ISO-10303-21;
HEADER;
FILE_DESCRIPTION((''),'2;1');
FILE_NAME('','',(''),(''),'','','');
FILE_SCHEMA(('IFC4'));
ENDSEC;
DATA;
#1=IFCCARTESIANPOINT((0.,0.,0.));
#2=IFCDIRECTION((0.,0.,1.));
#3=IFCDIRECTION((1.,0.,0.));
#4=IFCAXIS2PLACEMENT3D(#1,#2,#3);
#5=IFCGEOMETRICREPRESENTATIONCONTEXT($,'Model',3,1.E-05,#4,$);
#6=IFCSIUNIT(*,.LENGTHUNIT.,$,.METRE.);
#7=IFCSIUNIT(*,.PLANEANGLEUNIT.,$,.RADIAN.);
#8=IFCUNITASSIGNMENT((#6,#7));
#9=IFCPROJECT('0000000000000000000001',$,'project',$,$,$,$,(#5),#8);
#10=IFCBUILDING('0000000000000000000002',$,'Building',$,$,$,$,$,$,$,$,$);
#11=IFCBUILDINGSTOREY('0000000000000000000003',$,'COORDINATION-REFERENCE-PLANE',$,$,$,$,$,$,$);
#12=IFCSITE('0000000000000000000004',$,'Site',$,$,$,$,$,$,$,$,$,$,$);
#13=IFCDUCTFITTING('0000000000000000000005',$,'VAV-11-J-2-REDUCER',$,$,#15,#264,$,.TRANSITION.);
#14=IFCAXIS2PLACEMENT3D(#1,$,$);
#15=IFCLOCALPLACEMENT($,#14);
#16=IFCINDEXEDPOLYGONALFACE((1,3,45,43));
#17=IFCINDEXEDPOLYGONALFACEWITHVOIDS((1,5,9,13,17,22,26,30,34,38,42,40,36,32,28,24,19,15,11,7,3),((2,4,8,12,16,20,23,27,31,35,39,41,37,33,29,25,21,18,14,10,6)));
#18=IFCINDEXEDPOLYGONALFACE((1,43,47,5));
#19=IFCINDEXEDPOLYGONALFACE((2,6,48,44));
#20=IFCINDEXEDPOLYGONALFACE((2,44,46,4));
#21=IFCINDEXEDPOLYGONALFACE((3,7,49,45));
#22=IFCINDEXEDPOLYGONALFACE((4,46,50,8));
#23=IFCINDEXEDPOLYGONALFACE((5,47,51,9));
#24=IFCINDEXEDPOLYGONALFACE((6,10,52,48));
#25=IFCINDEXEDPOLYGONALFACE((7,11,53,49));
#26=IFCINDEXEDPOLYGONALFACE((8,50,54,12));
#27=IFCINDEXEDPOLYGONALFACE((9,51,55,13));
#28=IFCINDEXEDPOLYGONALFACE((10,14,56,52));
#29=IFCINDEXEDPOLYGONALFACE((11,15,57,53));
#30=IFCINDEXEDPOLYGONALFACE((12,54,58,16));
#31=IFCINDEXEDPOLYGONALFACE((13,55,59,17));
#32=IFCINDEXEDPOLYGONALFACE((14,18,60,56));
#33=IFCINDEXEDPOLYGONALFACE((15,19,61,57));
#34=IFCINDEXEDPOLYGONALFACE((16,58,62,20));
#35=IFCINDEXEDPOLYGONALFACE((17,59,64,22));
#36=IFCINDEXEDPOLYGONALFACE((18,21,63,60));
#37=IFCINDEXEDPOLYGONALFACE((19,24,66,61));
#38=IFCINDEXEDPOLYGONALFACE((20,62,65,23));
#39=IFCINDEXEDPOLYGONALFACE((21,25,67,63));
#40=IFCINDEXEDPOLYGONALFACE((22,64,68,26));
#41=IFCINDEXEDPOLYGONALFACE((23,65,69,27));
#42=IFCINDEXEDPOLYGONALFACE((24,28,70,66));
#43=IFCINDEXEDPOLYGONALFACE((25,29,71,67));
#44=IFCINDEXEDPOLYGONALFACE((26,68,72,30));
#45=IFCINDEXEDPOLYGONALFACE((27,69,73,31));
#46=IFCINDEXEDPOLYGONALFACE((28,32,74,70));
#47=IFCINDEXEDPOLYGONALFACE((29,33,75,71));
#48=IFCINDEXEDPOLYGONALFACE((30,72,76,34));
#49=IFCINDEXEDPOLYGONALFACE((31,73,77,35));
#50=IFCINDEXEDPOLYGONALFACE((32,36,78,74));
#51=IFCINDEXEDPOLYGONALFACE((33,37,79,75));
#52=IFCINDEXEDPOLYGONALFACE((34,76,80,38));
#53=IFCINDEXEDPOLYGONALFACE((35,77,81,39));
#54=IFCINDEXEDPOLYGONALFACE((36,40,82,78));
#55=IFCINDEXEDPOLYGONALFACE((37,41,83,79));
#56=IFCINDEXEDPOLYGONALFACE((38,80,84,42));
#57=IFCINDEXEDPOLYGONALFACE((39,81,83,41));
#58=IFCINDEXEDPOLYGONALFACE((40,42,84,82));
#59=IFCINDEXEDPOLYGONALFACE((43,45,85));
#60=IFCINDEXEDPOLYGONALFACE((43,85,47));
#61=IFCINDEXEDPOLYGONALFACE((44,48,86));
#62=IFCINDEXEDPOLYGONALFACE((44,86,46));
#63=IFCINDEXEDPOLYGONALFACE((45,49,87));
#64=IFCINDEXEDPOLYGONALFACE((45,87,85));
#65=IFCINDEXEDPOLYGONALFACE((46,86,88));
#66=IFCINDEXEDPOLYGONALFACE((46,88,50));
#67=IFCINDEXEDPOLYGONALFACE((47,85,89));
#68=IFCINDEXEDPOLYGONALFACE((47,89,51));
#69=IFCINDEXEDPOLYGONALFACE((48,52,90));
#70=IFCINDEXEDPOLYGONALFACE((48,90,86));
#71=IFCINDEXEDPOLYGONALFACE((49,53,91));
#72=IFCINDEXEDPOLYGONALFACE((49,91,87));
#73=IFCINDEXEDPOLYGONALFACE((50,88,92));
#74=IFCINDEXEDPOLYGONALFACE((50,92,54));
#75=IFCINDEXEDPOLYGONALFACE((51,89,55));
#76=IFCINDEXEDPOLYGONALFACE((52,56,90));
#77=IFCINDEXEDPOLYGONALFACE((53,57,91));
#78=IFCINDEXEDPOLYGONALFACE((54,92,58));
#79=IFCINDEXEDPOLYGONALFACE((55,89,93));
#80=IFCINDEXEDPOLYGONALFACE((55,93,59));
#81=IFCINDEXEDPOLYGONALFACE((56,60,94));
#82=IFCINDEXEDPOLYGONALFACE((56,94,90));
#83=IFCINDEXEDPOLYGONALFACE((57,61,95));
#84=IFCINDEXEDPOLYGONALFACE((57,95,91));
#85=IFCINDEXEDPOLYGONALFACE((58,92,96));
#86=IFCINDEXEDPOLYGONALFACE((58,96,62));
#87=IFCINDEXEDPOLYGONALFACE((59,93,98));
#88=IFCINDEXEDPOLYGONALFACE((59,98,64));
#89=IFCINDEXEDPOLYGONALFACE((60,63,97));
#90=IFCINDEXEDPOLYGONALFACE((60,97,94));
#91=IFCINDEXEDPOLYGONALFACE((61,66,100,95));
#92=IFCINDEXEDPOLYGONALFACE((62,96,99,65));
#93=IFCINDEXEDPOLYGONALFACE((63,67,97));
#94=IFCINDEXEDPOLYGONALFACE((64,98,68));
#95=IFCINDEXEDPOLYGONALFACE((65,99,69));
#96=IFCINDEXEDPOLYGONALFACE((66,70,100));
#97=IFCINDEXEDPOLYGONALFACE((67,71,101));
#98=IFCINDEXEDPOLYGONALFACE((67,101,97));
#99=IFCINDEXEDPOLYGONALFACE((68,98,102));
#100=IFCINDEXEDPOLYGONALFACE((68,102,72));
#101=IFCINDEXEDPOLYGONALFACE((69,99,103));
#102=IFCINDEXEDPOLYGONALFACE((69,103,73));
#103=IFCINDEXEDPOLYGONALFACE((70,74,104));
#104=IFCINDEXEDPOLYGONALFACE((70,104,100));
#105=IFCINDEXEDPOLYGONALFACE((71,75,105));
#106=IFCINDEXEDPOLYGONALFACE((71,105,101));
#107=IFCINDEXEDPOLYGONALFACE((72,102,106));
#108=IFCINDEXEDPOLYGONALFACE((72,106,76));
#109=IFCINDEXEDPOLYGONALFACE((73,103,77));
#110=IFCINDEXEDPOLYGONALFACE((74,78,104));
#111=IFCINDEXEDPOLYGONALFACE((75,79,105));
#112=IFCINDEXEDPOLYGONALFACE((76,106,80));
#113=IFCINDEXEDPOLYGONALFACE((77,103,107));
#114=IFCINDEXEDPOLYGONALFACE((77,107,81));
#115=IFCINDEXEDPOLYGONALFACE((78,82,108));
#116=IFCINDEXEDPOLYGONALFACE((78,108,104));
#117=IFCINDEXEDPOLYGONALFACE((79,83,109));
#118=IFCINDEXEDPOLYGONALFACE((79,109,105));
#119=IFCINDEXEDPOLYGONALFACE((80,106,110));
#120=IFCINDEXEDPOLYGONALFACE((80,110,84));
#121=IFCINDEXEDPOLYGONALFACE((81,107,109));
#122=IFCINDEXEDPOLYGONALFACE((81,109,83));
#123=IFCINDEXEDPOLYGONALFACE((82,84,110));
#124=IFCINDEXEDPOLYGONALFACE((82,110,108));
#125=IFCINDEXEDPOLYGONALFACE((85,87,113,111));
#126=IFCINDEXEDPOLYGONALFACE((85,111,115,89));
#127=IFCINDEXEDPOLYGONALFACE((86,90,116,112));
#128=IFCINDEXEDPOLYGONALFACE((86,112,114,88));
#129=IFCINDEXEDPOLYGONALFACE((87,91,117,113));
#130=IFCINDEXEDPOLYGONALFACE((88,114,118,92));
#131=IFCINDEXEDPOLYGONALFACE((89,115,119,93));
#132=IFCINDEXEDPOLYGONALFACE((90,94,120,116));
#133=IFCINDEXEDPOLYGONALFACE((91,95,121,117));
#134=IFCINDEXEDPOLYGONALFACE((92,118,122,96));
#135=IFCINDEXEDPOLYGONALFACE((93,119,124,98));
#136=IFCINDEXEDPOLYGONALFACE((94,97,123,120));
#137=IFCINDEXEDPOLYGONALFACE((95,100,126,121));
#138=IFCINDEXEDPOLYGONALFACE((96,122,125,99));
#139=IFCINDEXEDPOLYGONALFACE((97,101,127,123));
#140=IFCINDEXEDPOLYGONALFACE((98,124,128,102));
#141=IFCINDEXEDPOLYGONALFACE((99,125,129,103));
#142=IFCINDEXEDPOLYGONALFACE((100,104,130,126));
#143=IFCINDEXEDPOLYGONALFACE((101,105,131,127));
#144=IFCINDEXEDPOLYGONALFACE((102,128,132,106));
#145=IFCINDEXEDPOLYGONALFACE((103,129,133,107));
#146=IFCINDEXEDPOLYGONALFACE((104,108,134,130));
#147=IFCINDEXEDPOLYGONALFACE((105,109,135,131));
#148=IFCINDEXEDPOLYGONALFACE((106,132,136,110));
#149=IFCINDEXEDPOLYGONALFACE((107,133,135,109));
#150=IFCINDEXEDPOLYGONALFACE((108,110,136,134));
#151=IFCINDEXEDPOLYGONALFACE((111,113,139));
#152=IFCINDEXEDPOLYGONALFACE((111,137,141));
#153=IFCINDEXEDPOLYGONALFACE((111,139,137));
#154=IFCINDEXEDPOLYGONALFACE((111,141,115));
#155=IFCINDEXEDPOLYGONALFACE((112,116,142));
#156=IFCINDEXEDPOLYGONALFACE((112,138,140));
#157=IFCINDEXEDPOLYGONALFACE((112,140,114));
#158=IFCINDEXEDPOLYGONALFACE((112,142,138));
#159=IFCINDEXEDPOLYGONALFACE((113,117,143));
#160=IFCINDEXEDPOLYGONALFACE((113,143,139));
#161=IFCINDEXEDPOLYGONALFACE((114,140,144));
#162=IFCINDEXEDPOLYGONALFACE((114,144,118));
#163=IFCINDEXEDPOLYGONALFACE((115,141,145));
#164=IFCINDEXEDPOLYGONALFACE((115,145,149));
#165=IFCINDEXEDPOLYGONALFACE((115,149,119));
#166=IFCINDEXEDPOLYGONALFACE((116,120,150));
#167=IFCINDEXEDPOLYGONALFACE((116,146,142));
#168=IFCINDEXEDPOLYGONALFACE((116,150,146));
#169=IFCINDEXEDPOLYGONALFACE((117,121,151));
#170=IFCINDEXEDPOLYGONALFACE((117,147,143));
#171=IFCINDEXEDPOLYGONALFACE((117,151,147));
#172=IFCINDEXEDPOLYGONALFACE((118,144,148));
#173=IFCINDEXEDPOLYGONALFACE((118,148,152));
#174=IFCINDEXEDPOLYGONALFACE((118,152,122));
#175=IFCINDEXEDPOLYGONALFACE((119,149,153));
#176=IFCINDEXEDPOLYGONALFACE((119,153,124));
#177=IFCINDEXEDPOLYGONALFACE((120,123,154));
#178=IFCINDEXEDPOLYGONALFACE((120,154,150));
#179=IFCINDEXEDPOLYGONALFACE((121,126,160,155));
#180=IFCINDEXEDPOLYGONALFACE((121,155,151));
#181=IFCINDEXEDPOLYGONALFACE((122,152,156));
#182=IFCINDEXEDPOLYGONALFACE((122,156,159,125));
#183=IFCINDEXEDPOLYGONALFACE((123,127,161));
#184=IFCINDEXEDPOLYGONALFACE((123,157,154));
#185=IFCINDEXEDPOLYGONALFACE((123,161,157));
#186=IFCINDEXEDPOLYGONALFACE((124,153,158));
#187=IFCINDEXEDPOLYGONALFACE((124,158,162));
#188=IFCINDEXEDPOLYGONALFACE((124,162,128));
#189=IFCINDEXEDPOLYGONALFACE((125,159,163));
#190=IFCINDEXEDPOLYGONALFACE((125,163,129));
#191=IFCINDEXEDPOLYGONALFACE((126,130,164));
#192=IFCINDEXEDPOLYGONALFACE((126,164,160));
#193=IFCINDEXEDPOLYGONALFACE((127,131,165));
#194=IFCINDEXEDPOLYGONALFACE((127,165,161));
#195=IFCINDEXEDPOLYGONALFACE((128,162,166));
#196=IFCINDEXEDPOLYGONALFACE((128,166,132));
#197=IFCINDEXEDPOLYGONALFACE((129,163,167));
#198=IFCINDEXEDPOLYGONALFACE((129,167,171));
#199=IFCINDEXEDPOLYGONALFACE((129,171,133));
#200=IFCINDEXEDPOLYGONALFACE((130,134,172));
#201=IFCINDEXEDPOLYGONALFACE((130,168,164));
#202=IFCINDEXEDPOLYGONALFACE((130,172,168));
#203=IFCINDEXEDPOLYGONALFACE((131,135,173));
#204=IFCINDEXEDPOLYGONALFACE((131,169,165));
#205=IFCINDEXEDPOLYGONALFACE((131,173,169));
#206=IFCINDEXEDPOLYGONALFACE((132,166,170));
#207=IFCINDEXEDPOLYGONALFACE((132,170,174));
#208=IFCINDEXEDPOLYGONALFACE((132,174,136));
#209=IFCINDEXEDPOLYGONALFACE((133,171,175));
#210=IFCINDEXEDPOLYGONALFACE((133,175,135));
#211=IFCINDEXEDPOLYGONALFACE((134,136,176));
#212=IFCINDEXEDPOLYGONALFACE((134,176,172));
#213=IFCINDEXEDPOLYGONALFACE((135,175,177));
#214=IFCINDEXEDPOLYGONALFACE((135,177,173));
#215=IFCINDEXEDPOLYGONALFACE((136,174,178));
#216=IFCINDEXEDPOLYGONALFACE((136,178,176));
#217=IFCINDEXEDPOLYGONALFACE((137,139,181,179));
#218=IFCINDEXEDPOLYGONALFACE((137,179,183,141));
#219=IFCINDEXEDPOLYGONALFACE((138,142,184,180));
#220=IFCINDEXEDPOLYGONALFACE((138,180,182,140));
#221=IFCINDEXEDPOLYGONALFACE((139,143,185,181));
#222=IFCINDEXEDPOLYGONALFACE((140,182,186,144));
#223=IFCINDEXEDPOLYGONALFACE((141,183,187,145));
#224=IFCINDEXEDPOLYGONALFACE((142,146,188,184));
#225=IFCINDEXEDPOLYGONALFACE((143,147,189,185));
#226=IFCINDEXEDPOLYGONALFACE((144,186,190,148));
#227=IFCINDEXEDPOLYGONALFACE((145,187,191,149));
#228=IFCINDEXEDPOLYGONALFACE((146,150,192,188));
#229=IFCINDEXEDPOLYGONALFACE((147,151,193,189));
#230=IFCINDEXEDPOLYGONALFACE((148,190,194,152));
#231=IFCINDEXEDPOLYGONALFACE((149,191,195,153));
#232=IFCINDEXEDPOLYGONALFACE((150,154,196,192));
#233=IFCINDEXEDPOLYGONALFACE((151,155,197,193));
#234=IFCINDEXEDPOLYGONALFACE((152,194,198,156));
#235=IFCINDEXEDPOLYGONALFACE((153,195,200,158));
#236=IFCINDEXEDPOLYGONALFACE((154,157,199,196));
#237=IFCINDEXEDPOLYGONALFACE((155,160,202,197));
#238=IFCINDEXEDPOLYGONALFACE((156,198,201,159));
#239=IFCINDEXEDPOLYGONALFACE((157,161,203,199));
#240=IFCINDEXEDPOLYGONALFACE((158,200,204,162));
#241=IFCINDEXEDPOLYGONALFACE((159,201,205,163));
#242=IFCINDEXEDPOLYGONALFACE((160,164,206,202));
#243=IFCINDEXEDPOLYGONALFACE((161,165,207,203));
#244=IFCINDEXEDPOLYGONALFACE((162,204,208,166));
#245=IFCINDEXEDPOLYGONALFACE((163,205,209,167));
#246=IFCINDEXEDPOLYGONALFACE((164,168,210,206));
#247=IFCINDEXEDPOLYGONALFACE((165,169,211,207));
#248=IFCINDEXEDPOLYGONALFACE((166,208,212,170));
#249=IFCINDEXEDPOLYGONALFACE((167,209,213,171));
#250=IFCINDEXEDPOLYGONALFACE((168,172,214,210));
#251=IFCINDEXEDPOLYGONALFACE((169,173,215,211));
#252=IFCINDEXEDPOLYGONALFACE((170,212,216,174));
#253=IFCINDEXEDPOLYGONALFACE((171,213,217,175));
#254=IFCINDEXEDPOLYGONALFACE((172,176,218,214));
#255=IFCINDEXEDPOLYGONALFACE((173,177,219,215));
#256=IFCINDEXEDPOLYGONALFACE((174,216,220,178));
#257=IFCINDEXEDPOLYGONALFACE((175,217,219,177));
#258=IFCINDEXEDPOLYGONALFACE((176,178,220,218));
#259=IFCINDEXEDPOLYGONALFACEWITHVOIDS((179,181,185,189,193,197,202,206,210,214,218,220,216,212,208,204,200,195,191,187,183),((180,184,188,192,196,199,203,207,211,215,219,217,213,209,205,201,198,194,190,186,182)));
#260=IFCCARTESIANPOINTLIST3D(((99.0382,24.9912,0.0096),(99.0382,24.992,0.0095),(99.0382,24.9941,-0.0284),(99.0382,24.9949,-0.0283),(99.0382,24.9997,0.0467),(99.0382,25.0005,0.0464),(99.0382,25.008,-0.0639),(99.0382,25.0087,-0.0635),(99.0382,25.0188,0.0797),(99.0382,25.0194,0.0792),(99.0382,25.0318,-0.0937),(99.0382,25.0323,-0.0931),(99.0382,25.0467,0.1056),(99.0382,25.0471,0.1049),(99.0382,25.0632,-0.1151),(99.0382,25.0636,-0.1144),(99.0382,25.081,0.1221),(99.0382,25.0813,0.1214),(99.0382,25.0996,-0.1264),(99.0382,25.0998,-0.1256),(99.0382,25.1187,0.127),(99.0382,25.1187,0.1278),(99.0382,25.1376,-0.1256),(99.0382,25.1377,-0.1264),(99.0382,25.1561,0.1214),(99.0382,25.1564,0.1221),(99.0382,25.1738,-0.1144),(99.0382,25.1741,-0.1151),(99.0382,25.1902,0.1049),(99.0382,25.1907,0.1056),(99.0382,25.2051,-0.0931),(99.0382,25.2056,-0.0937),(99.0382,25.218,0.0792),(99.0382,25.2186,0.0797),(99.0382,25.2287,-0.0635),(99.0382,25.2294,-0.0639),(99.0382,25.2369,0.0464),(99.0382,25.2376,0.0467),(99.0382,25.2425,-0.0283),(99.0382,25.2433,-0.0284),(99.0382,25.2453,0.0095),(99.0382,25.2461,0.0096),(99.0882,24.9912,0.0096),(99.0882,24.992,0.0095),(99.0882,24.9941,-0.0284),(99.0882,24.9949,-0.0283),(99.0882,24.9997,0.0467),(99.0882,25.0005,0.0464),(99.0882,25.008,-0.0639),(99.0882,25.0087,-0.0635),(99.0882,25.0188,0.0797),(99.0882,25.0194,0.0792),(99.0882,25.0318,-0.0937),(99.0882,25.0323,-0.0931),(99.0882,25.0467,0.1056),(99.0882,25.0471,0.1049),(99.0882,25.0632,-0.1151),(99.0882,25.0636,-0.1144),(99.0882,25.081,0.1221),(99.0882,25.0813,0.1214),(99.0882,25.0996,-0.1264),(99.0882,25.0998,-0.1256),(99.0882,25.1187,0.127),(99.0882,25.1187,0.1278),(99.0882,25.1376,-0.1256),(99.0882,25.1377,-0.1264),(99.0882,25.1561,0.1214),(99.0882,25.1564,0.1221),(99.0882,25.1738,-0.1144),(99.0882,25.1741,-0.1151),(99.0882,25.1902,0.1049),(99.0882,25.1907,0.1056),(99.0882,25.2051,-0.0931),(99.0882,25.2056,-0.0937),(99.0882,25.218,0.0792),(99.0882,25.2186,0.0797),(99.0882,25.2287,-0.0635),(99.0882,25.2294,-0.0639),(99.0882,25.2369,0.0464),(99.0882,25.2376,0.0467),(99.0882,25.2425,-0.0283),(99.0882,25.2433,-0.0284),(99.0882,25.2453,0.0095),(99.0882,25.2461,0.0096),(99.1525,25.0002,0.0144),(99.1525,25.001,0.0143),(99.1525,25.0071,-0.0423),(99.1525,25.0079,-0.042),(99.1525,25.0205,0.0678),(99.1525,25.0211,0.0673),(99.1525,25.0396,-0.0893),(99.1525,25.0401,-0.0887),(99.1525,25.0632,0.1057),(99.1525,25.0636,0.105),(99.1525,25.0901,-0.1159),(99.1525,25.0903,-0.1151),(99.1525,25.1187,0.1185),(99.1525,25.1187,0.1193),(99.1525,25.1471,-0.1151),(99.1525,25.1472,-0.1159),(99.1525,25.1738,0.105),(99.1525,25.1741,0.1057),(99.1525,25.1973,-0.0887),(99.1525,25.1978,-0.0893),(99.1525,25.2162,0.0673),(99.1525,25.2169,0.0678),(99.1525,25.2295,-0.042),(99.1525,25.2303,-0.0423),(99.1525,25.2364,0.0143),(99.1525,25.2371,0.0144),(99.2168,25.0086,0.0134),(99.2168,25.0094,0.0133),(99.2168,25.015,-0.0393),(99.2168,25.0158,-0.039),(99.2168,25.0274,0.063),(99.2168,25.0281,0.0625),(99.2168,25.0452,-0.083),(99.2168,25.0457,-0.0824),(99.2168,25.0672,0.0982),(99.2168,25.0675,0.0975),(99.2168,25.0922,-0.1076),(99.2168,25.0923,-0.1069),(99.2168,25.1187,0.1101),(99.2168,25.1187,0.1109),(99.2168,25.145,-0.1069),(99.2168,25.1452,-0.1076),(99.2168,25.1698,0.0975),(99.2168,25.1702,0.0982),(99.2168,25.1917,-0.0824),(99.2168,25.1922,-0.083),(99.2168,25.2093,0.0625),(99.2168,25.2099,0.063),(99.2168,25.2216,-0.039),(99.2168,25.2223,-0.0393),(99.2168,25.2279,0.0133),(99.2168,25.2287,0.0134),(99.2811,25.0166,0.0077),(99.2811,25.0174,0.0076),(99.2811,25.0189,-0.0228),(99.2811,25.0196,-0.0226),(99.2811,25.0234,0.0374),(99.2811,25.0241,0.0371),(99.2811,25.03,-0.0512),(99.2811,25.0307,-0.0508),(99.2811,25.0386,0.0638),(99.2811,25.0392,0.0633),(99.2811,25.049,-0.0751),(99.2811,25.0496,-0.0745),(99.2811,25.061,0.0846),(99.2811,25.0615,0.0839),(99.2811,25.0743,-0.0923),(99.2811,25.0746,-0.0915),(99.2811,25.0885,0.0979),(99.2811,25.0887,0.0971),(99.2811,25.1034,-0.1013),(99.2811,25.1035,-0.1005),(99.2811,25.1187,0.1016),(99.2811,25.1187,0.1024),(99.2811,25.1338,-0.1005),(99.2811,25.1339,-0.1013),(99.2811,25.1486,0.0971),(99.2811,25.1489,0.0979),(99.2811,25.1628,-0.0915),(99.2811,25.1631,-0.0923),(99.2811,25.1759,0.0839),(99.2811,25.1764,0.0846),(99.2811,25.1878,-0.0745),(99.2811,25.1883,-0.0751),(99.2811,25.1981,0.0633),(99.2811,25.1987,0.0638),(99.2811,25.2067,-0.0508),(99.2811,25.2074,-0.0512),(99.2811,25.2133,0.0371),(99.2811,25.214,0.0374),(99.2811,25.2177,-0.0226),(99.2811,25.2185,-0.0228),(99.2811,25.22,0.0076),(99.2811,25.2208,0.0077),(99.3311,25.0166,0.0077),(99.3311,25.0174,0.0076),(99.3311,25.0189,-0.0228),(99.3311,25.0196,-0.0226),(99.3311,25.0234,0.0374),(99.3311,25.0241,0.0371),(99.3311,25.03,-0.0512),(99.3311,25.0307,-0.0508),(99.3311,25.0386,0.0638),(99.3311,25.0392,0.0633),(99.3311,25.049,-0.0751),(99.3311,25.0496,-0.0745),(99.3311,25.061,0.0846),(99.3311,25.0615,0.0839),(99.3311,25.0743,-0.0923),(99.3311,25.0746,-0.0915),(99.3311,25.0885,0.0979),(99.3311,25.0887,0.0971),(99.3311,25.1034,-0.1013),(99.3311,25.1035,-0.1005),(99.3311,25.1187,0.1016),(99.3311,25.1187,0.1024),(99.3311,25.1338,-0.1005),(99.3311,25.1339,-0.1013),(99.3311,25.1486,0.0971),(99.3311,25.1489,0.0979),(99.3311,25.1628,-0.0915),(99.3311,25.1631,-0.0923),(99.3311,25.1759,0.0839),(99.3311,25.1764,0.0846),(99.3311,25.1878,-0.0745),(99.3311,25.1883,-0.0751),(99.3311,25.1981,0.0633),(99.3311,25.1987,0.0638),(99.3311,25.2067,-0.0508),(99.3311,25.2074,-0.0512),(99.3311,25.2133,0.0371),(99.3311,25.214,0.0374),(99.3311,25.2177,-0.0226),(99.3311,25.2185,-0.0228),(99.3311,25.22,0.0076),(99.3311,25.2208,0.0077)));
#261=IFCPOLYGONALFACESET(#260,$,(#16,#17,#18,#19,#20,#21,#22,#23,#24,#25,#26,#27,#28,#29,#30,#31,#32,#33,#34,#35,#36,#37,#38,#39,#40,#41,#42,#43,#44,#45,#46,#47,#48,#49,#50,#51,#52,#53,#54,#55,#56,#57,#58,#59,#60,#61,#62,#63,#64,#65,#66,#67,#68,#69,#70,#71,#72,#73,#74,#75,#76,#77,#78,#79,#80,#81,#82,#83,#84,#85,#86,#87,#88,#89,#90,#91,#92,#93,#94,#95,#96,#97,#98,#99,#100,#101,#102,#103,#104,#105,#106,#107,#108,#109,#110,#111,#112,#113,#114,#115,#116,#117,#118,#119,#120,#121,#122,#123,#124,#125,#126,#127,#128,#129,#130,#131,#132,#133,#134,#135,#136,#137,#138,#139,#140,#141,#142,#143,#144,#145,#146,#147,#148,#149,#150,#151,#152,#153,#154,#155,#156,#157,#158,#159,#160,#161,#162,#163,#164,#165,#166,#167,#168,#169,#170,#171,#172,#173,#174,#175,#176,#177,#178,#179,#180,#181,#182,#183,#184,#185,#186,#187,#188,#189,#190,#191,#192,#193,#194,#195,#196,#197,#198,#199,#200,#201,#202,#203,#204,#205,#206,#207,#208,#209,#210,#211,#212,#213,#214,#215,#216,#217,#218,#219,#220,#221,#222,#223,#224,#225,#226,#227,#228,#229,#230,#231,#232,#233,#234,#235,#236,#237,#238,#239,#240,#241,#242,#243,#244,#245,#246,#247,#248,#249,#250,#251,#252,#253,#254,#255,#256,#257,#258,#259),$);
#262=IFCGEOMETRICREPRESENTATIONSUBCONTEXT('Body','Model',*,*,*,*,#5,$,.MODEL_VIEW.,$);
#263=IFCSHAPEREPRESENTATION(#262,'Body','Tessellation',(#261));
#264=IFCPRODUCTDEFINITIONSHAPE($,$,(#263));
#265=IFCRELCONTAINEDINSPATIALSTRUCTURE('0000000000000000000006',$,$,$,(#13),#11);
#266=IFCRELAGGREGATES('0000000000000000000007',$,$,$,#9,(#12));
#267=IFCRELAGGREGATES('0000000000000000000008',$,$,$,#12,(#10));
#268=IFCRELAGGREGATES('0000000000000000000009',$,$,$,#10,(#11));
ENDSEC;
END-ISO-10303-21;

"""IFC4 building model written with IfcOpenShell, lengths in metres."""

from ifc_helpers import new_model, entity, si_unit, frame, origin_with_axes, place, context, subcontext, project, spatial, element, save


model = new_model("IFC4")

# Units and contexts
model_context_1 = context("Model", 3, precision=1e-05, world=origin_with_axes())
body_context_1 = subcontext(model_context_1, "Body", "Model", "MODEL_VIEW")
ifc_project = project(units=[si_unit("LENGTHUNIT", "METRE"), si_unit("PLANEANGLEUNIT", "RADIAN")], contexts=[model_context_1])

# Site, building, storey
site = spatial("IfcSite", under=ifc_project, Name="Site")
building = spatial("IfcBuilding", under=site, Name="Building")
storey = spatial("IfcBuildingStorey", under=building, Name="COORDINATION-REFERENCE-PLANE")

# Duct fitting
for number, where, z_axis, x_axis, name in (
    (1, (99.0382, 25.1187, 0.0), (0.0, 1.0, 0.0), (0.0, 0.0, 1.0), "VAV-11-J-2-REDUCER"),
):
    element("IfcDuctFitting", number, at=place(None, frame(where, z_axis=z_axis, x_axis=x_axis)), inside=storey, Name=name, PredefinedType="TRANSITION", context=body_context_1, shape_type="SweptSolid", body=[
        entity("IfcRevolvedAreaSolid", entity("IfcArbitraryClosedProfileDef", "AREA", None, entity("IfcPolyline", [entity("IfcCartesianPoint", [0.1278, 0.0]), entity("IfcCartesianPoint", [0.1278, 0.05]), entity("IfcCartesianPoint", [0.1024, 0.2429]), entity("IfcCartesianPoint", [0.1024, 0.2929]), entity("IfcCartesianPoint", [0.1016, 0.2929]), entity("IfcCartesianPoint", [0.1016, 0.2429]), entity("IfcCartesianPoint", [0.127, 0.05]), entity("IfcCartesianPoint", [0.127, 0.0]), entity("IfcCartesianPoint", [0.1278, 0.0])])), entity("IfcAxis2Placement3D", entity("IfcCartesianPoint", [0.0, 0.0, 0.0])), entity("IfcAxis1Placement", entity("IfcCartesianPoint", [0.0, 0.0, 0.0]), entity("IfcDirection", [0.0, 1.0, 0.0])), 6.283185),
    ])

save(model, "model.ifc")
